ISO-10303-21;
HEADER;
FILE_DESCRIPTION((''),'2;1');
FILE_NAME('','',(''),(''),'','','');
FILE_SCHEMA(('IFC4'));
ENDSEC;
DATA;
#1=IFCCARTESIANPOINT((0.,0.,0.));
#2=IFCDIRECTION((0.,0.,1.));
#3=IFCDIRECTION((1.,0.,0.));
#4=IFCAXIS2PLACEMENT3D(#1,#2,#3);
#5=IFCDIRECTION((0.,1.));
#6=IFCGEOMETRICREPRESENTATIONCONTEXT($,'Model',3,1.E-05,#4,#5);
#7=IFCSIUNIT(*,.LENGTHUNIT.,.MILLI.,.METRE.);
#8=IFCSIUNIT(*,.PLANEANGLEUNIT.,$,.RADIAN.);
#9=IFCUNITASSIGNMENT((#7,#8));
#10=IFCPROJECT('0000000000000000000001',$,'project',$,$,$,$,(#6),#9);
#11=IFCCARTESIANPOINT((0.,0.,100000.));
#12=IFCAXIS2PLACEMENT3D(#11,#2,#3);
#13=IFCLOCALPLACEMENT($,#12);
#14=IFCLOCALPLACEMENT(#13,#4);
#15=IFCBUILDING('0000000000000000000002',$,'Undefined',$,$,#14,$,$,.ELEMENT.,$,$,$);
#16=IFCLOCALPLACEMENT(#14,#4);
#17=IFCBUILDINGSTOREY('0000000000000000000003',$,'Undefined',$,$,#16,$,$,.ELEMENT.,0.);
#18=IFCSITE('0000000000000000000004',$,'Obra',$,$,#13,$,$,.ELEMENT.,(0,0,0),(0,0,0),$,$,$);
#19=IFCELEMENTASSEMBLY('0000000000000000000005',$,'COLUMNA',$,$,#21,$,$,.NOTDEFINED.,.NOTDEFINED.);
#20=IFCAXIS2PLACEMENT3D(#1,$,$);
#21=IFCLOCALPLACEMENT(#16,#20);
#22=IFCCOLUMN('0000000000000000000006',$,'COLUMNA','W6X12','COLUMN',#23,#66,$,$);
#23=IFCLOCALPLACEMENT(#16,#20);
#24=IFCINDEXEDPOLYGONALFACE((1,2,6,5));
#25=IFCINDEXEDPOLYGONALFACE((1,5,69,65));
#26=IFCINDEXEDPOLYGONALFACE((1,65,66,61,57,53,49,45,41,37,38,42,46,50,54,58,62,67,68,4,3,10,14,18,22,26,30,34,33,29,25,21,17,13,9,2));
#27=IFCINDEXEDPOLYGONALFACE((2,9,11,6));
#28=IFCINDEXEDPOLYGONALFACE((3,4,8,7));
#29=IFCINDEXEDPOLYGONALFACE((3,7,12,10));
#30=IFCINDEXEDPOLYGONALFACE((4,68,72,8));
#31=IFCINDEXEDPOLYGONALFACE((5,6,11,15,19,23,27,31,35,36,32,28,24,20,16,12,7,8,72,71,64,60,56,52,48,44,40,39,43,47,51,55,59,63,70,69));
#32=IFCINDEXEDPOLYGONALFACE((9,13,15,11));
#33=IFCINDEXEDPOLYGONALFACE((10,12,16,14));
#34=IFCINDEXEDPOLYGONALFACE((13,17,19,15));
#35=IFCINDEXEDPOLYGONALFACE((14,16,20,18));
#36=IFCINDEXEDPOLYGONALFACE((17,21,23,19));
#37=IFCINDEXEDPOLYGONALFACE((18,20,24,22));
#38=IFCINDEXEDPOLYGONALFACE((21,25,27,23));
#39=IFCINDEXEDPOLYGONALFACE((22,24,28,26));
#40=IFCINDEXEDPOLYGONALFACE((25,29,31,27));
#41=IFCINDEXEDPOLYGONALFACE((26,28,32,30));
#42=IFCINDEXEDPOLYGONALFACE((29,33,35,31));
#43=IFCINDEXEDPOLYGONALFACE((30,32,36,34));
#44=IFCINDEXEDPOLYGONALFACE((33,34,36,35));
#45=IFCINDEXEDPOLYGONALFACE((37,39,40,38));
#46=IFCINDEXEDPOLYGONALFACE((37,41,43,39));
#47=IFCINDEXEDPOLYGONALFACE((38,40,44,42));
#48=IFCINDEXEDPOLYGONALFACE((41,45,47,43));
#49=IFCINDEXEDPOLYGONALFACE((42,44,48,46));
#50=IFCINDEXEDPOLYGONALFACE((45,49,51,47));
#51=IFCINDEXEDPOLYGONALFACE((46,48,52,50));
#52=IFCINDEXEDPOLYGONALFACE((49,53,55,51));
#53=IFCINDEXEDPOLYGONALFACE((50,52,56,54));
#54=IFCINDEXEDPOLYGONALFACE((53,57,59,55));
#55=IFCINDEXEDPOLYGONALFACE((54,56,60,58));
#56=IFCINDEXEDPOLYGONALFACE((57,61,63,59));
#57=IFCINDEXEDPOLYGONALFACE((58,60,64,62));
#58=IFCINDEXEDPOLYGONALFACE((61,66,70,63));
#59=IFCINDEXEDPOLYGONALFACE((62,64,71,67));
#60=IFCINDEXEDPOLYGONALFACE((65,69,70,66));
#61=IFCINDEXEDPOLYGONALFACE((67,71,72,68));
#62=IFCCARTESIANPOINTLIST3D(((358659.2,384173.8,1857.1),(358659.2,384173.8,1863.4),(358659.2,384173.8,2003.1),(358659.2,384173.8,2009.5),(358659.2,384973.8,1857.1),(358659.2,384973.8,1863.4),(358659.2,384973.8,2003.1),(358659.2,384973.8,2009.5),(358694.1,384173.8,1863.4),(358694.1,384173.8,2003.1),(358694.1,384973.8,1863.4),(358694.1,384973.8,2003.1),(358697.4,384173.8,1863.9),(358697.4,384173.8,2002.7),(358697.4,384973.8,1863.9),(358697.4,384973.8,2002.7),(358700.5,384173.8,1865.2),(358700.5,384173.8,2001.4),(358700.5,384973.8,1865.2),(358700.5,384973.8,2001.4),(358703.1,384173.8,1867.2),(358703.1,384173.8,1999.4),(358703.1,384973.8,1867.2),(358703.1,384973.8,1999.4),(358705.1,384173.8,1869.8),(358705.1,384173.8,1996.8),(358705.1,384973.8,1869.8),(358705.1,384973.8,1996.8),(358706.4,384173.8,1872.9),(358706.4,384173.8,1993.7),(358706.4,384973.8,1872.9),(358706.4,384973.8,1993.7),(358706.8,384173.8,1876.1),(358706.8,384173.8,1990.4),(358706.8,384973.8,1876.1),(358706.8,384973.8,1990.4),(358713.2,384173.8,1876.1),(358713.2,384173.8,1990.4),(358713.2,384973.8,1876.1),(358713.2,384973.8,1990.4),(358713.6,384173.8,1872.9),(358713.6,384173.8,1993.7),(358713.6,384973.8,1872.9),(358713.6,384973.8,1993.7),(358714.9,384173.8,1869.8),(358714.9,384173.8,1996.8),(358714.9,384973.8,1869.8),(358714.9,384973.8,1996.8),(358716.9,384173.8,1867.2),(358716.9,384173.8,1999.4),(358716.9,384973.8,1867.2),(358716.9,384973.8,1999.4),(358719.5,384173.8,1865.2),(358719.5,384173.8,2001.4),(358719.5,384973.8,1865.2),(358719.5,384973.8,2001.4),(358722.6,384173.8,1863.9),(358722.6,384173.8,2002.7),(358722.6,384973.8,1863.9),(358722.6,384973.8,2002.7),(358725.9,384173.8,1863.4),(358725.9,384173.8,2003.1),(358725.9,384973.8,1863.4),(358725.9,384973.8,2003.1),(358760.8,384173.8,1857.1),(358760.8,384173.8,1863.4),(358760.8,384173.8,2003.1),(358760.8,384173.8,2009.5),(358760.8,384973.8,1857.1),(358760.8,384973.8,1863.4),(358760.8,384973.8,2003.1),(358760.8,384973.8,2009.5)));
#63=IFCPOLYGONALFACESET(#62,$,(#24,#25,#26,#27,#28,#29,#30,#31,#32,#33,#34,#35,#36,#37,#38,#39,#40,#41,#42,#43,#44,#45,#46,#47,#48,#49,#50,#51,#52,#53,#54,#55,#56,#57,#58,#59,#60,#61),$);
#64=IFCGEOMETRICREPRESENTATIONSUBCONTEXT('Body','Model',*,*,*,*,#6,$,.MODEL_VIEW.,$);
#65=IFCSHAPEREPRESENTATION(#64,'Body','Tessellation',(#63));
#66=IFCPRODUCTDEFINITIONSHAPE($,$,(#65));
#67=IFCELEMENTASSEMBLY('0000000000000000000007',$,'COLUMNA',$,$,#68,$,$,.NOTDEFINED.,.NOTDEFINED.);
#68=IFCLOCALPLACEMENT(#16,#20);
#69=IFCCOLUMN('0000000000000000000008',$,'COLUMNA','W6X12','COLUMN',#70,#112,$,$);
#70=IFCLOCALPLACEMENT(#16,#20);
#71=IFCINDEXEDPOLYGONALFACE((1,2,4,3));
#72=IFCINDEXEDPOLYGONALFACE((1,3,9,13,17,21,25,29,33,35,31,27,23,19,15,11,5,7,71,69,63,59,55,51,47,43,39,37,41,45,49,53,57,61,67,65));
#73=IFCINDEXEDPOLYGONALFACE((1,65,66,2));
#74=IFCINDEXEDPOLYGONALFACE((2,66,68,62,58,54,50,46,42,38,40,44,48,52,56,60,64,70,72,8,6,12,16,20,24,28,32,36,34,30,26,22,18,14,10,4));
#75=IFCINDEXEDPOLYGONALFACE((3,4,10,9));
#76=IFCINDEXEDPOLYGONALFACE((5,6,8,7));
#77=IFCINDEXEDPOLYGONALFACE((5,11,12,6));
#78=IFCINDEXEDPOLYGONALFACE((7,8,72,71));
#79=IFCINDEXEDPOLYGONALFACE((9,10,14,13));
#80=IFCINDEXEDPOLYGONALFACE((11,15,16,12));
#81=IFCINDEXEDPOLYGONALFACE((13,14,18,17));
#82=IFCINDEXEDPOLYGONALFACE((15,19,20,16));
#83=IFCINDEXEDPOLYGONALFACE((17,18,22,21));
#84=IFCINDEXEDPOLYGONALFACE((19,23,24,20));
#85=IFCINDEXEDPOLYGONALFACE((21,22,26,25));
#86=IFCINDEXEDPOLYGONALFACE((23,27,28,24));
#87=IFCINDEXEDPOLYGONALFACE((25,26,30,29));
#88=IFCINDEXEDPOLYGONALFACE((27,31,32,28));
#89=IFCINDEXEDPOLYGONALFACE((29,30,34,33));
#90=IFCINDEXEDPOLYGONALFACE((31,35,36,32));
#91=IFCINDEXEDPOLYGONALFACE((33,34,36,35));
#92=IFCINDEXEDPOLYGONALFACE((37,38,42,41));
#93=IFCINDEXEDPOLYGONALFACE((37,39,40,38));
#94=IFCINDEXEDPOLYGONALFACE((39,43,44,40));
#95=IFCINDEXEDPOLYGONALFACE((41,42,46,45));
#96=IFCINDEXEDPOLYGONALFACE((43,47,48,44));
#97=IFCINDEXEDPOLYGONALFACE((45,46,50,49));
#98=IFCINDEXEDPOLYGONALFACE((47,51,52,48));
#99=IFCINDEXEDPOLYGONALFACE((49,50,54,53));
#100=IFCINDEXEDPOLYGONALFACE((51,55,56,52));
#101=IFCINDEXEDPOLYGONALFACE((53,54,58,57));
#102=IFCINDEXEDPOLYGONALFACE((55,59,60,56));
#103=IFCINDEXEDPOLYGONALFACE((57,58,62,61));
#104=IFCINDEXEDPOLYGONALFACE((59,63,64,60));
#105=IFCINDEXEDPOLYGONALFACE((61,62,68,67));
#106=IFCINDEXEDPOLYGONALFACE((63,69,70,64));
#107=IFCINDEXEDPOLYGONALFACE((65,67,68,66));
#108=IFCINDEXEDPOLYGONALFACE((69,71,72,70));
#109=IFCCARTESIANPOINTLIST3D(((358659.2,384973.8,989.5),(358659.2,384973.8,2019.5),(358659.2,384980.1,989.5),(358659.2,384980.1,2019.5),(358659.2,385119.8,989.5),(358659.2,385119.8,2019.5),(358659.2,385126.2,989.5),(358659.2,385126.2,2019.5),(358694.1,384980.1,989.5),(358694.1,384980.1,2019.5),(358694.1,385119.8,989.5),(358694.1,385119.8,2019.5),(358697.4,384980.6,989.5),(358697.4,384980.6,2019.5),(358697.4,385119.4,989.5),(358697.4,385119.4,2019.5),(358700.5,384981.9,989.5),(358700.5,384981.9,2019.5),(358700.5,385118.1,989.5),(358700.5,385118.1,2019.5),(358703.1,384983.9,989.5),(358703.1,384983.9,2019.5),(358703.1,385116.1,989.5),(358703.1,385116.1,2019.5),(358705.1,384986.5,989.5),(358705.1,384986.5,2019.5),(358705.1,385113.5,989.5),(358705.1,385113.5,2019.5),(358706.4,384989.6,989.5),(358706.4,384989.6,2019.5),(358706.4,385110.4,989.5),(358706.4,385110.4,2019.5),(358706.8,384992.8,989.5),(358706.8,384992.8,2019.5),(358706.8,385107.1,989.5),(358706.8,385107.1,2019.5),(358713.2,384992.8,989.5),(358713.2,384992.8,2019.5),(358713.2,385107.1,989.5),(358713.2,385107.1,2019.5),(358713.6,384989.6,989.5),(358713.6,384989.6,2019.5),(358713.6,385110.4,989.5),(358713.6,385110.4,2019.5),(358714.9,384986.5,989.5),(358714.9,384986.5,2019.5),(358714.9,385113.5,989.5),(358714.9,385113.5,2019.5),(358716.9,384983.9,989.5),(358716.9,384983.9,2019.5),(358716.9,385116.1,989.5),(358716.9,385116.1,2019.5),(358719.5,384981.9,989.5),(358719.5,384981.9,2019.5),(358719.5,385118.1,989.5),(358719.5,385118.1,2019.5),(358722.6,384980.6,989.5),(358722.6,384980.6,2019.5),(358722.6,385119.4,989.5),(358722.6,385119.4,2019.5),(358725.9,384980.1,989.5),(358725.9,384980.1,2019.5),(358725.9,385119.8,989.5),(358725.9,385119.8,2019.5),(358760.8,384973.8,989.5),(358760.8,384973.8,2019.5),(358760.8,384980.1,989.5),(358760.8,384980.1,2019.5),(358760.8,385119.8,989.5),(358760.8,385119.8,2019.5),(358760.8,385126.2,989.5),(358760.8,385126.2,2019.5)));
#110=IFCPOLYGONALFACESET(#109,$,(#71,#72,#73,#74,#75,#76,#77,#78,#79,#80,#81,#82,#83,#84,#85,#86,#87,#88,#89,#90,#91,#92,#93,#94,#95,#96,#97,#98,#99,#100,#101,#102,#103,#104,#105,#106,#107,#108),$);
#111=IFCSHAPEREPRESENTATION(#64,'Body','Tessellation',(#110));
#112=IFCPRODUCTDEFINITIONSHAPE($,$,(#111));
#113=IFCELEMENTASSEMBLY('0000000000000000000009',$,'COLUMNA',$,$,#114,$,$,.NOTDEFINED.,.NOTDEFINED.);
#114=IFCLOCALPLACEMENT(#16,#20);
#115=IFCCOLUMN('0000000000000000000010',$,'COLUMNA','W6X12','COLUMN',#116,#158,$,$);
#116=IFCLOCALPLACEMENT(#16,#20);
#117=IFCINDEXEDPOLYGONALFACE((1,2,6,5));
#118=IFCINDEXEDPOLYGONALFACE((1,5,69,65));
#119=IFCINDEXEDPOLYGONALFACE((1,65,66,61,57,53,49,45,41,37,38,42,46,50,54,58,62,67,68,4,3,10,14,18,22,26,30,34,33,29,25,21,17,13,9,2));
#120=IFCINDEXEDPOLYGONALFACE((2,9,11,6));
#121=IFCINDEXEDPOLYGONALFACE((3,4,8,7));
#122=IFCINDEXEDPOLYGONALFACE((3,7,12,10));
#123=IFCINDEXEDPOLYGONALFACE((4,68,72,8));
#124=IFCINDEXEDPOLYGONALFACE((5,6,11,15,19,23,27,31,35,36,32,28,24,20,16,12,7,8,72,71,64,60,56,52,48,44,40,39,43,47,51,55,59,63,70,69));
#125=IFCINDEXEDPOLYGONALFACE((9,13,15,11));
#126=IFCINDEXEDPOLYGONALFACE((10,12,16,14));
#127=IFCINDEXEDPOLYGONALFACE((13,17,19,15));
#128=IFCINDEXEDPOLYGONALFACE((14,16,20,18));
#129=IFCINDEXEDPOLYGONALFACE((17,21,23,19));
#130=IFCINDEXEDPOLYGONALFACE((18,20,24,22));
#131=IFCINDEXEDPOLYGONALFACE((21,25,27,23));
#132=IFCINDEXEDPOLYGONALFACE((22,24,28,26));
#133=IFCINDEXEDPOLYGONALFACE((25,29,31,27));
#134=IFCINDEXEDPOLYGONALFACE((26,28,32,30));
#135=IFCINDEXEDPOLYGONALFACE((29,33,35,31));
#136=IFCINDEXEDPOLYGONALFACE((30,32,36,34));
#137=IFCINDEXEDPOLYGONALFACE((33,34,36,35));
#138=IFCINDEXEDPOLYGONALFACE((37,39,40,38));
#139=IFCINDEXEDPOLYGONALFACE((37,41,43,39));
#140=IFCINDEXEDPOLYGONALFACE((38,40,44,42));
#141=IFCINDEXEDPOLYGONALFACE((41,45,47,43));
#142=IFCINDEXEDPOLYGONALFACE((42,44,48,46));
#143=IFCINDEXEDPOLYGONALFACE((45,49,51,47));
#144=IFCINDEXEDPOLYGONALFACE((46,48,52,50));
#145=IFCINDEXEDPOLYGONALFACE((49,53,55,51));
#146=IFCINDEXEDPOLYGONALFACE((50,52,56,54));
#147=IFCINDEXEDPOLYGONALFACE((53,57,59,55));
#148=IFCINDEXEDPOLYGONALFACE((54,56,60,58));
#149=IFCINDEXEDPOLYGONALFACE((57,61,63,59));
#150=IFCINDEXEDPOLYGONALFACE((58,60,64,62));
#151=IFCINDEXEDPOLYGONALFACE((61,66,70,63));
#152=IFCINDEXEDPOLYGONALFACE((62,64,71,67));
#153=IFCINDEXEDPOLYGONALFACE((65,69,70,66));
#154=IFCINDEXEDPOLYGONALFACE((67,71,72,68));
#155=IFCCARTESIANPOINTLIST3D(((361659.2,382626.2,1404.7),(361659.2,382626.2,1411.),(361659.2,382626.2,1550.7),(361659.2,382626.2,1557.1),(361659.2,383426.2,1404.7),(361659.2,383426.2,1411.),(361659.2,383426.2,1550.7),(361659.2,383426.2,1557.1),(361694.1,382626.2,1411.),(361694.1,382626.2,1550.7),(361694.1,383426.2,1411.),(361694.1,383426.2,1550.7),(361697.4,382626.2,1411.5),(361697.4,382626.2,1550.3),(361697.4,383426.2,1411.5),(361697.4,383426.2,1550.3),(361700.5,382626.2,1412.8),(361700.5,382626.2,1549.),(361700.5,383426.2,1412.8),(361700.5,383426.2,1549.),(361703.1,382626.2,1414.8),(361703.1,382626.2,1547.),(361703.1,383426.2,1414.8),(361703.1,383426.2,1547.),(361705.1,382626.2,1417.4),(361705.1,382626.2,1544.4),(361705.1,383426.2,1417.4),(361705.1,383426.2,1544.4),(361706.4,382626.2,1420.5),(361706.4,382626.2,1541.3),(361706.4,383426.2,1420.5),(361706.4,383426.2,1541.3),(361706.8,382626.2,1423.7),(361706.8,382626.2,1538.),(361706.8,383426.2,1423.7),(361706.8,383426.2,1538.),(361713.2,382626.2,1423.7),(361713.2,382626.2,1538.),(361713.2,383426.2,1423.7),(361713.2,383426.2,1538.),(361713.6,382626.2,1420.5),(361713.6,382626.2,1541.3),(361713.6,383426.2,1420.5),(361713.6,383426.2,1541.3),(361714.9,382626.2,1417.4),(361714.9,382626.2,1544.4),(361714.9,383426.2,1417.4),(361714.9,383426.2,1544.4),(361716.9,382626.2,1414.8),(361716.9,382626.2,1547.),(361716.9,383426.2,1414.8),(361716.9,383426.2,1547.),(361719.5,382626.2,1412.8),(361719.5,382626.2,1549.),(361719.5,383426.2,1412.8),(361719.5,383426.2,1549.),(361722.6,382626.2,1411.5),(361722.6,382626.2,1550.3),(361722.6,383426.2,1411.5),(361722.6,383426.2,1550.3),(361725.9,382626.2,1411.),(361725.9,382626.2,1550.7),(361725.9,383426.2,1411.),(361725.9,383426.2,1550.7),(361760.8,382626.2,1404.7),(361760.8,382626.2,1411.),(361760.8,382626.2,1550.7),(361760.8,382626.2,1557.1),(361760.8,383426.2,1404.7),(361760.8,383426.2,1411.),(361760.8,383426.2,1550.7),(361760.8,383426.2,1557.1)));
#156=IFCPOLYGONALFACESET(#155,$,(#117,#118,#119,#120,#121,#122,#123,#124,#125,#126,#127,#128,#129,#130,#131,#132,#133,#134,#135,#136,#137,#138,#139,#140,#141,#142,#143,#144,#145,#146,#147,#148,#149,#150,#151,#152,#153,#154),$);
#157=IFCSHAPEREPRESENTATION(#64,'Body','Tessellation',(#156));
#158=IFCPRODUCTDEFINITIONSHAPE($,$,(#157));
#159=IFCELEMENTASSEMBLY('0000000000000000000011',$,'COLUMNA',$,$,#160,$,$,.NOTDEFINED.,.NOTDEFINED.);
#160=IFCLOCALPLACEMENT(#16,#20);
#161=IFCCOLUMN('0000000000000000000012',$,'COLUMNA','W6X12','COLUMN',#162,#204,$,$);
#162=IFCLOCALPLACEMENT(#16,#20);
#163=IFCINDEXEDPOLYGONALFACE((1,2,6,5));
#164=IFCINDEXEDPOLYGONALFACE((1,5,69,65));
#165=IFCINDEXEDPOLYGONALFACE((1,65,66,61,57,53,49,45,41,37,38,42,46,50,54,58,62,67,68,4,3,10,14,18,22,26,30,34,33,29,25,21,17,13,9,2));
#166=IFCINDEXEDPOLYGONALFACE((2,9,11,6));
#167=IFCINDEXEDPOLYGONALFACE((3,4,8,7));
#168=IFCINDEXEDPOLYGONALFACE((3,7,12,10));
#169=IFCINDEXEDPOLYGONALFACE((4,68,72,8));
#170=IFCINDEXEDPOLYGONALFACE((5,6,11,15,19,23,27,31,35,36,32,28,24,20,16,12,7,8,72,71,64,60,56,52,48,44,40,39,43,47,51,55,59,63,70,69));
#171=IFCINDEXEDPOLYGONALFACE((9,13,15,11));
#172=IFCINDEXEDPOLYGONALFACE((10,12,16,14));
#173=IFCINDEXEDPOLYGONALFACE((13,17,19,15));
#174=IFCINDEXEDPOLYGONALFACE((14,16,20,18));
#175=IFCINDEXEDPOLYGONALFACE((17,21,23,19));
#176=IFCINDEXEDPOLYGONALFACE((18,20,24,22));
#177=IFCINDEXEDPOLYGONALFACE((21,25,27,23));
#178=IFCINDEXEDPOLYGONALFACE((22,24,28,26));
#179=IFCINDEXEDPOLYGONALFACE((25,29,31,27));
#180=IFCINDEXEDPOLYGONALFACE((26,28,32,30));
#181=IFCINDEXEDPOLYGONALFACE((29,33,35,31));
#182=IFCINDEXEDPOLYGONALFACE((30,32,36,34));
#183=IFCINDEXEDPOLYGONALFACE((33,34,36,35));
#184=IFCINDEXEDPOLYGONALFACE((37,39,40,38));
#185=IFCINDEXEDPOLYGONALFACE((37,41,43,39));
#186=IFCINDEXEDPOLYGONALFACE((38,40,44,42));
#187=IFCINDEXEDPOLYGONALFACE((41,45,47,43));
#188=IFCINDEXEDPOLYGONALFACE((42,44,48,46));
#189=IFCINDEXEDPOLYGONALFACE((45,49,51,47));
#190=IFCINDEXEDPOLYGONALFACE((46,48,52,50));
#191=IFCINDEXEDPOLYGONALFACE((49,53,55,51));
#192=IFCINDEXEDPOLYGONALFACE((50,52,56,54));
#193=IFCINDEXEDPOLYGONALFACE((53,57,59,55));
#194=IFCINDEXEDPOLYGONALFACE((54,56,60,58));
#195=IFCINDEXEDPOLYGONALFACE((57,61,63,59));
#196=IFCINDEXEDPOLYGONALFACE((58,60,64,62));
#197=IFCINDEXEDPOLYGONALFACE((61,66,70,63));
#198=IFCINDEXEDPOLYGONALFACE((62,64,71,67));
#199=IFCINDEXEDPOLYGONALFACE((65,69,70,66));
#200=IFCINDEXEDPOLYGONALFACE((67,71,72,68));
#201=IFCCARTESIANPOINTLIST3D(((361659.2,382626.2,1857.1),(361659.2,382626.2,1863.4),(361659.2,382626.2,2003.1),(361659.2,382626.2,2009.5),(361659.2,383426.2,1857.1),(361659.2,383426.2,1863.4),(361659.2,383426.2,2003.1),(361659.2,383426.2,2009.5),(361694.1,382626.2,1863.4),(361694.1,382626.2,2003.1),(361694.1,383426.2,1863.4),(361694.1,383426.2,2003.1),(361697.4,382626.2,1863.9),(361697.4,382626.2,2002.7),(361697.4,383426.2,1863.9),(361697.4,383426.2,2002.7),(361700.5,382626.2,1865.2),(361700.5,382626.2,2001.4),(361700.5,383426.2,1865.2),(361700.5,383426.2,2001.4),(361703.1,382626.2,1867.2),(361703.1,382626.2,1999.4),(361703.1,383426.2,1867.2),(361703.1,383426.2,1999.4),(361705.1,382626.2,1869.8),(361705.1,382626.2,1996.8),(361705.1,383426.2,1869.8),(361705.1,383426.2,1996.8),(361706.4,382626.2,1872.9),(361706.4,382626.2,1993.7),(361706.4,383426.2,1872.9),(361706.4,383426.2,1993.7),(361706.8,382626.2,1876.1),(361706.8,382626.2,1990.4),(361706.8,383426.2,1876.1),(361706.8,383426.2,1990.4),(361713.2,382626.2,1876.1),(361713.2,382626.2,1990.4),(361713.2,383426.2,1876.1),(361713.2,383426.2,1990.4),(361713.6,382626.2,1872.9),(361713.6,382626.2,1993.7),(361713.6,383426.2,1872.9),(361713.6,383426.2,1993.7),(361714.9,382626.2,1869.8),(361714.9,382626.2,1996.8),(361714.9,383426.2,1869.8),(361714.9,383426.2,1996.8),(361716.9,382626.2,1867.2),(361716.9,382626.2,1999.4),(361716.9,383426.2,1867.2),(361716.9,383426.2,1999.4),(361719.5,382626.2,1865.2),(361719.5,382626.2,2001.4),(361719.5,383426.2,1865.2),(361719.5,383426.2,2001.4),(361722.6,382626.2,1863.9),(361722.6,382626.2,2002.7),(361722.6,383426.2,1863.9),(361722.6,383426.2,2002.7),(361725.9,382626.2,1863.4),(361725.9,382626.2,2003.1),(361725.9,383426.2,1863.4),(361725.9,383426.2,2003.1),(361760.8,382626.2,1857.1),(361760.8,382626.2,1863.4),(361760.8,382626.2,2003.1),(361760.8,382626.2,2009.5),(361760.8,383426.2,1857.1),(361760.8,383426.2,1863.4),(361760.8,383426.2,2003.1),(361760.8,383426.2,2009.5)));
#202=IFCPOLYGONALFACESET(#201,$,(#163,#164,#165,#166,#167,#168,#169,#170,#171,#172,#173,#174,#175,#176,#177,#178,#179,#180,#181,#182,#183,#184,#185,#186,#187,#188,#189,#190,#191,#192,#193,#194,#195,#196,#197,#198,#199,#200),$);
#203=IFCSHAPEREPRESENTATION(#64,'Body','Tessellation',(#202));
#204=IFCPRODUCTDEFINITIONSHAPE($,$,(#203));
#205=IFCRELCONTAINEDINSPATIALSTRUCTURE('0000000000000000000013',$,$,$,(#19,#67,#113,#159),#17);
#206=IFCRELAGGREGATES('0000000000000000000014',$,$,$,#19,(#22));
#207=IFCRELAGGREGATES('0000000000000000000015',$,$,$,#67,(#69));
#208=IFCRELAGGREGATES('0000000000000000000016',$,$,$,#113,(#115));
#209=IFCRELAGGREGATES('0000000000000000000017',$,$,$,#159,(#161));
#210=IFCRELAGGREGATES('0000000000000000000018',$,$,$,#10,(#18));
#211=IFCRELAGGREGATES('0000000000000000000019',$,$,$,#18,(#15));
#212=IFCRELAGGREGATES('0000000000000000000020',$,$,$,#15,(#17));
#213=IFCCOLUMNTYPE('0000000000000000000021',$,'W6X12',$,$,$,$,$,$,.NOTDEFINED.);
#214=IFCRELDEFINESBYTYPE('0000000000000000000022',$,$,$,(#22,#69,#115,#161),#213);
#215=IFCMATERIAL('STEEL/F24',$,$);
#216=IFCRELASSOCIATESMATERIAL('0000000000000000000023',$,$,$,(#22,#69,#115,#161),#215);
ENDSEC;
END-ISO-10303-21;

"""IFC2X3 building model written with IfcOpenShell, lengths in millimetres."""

from ifc_helpers import new_model, si_unit, direction, frame, origin_with_axes, origin_2d_with_axis, place, context, subcontext, project, spatial, i_section, extrude, material, type_object, element, aggregate, save


model = new_model("IFC2X3")

# Units and contexts
model_context = context("Model", 3, precision=1e-05, world=origin_with_axes(), true_north=direction((0.0, 1.0)))
body_context = subcontext(model_context, "Body", "Model", "MODEL_VIEW")
ifc_project = project(units=[si_unit("LENGTHUNIT", "METRE", prefix="MILLI"), si_unit("PLANEANGLEUNIT", "RADIAN")], contexts=[model_context])

# Site, building, storey
site_placement = place(None, frame((0.0, 0.0, 100000.0), z_axis=(0.0, 0.0, 1.0), x_axis=(1.0, 0.0, 0.0)))
site = spatial("IfcSite", under=ifc_project, at=site_placement, Name="Obra", CompositionType="ELEMENT", RefLatitude=(0, 0, 0), RefLongitude=(0, 0, 0))
building_placement = place(site_placement, origin_with_axes())
building = spatial("IfcBuilding", under=site, at=building_placement, Name="Undefined", CompositionType="ELEMENT")
storey_placement = place(building_placement, origin_with_axes())
storey = spatial("IfcBuildingStorey", under=building, at=storey_placement, Name="Undefined", CompositionType="ELEMENT", Elevation=0.0)

# Element assemblies, columns
ifc_material_1 = material(Name="STEEL/F24")
column_type_1 = type_object("IfcColumnType", Name="W6X12", PredefinedType="NOTDEFINED")
assembly_1_placement = place(storey_placement, origin_with_axes())
assembly_1 = element("IfcElementAssembly", 1, at=assembly_1_placement, inside=storey, Name="COLUMNA", AssemblyPlace="NOTDEFINED", PredefinedType="NOTDEFINED")
column_1_placement = place(assembly_1_placement, frame((358710.0, 384973.8, 1933.3), z_axis=(0.0, -1.0, 0.0), x_axis=(0.0, 0.0, -1.0)))
column_1 = element("IfcColumn", 2, at=column_1_placement, type_object=column_type_1, material=ifc_material_1, Name="COLUMNA", Description="W6X12", ObjectType="COLUMN", context=body_context, shape_type="SweptSolid", body=[
    extrude(i_section(OverallWidth=101.6, OverallDepth=152.4, WebThickness=6.3, FlangeThickness=6.3, FilletRadius=12.7, at=origin_2d_with_axis()), frame((0.0, 0.0, 800.0), z_axis=(0.0, 0.0, -1.0), x_axis=(0.0, 1.0, 0.0)), (0.0, 0.0, 1.0), 800.0),
])
aggregate(assembly_1, [column_1])
assembly_2_placement = place(storey_placement, origin_with_axes())
assembly_2 = element("IfcElementAssembly", 3, at=assembly_2_placement, inside=storey, Name="COLUMNA", AssemblyPlace="NOTDEFINED", PredefinedType="NOTDEFINED")
column_2_placement = place(assembly_2_placement, frame((358710.0, 385050.0, 989.5), z_axis=(0.0, 0.0, 1.0), x_axis=(0.0, 1.0, 0.0)))
column_2 = element("IfcColumn", 4, at=column_2_placement, type_object=column_type_1, material=ifc_material_1, Name="COLUMNA", Description="W6X12", ObjectType="COLUMN", context=body_context, shape_type="SweptSolid", body=[
    extrude(i_section(OverallWidth=101.6, OverallDepth=152.4, WebThickness=6.3, FlangeThickness=6.3, FilletRadius=12.7, at=origin_2d_with_axis()), frame((0.0, 0.0, 1030.0), z_axis=(0.0, 0.0, -1.0), x_axis=(0.0, 1.0, 0.0)), (0.0, 0.0, 1.0), 1030.0),
])
aggregate(assembly_2, [column_2])
assembly_3_placement = place(storey_placement, origin_with_axes())
assembly_3 = element("IfcElementAssembly", 5, at=assembly_3_placement, inside=storey, Name="COLUMNA", AssemblyPlace="NOTDEFINED", PredefinedType="NOTDEFINED")
column_3_placement = place(assembly_3_placement, frame((361710.0, 382626.2, 1480.9), z_axis=(0.0, 1.0, 0.0), x_axis=(0.0, 0.0, -1.0)))
column_3 = element("IfcColumn", 6, at=column_3_placement, type_object=column_type_1, material=ifc_material_1, Name="COLUMNA", Description="W6X12", ObjectType="COLUMN", context=body_context, shape_type="SweptSolid", body=[
    extrude(i_section(OverallWidth=101.6, OverallDepth=152.4, WebThickness=6.3, FlangeThickness=6.3, FilletRadius=12.7, at=origin_2d_with_axis()), frame((0.0, 0.0, 800.0), z_axis=(0.0, 0.0, -1.0), x_axis=(0.0, 1.0, 0.0)), (0.0, 0.0, 1.0), 800.0),
])
aggregate(assembly_3, [column_3])
assembly_4_placement = place(storey_placement, origin_with_axes())
assembly_4 = element("IfcElementAssembly", 7, at=assembly_4_placement, inside=storey, Name="COLUMNA", AssemblyPlace="NOTDEFINED", PredefinedType="NOTDEFINED")
column_4_placement = place(assembly_4_placement, frame((361710.0, 382626.2, 1933.3), z_axis=(0.0, 1.0, 0.0), x_axis=(0.0, 0.0, -1.0)))
column_4 = element("IfcColumn", 8, at=column_4_placement, type_object=column_type_1, material=ifc_material_1, Name="COLUMNA", Description="W6X12", ObjectType="COLUMN", context=body_context, shape_type="SweptSolid", body=[
    extrude(i_section(OverallWidth=101.6, OverallDepth=152.4, WebThickness=6.3, FlangeThickness=6.3, FilletRadius=12.7, at=origin_2d_with_axis()), frame((0.0, 0.0, 800.0), z_axis=(0.0, 0.0, -1.0), x_axis=(0.0, 1.0, 0.0)), (0.0, 0.0, 1.0), 800.0),
])
aggregate(assembly_4, [column_4])

save(model, "model.ifc")
